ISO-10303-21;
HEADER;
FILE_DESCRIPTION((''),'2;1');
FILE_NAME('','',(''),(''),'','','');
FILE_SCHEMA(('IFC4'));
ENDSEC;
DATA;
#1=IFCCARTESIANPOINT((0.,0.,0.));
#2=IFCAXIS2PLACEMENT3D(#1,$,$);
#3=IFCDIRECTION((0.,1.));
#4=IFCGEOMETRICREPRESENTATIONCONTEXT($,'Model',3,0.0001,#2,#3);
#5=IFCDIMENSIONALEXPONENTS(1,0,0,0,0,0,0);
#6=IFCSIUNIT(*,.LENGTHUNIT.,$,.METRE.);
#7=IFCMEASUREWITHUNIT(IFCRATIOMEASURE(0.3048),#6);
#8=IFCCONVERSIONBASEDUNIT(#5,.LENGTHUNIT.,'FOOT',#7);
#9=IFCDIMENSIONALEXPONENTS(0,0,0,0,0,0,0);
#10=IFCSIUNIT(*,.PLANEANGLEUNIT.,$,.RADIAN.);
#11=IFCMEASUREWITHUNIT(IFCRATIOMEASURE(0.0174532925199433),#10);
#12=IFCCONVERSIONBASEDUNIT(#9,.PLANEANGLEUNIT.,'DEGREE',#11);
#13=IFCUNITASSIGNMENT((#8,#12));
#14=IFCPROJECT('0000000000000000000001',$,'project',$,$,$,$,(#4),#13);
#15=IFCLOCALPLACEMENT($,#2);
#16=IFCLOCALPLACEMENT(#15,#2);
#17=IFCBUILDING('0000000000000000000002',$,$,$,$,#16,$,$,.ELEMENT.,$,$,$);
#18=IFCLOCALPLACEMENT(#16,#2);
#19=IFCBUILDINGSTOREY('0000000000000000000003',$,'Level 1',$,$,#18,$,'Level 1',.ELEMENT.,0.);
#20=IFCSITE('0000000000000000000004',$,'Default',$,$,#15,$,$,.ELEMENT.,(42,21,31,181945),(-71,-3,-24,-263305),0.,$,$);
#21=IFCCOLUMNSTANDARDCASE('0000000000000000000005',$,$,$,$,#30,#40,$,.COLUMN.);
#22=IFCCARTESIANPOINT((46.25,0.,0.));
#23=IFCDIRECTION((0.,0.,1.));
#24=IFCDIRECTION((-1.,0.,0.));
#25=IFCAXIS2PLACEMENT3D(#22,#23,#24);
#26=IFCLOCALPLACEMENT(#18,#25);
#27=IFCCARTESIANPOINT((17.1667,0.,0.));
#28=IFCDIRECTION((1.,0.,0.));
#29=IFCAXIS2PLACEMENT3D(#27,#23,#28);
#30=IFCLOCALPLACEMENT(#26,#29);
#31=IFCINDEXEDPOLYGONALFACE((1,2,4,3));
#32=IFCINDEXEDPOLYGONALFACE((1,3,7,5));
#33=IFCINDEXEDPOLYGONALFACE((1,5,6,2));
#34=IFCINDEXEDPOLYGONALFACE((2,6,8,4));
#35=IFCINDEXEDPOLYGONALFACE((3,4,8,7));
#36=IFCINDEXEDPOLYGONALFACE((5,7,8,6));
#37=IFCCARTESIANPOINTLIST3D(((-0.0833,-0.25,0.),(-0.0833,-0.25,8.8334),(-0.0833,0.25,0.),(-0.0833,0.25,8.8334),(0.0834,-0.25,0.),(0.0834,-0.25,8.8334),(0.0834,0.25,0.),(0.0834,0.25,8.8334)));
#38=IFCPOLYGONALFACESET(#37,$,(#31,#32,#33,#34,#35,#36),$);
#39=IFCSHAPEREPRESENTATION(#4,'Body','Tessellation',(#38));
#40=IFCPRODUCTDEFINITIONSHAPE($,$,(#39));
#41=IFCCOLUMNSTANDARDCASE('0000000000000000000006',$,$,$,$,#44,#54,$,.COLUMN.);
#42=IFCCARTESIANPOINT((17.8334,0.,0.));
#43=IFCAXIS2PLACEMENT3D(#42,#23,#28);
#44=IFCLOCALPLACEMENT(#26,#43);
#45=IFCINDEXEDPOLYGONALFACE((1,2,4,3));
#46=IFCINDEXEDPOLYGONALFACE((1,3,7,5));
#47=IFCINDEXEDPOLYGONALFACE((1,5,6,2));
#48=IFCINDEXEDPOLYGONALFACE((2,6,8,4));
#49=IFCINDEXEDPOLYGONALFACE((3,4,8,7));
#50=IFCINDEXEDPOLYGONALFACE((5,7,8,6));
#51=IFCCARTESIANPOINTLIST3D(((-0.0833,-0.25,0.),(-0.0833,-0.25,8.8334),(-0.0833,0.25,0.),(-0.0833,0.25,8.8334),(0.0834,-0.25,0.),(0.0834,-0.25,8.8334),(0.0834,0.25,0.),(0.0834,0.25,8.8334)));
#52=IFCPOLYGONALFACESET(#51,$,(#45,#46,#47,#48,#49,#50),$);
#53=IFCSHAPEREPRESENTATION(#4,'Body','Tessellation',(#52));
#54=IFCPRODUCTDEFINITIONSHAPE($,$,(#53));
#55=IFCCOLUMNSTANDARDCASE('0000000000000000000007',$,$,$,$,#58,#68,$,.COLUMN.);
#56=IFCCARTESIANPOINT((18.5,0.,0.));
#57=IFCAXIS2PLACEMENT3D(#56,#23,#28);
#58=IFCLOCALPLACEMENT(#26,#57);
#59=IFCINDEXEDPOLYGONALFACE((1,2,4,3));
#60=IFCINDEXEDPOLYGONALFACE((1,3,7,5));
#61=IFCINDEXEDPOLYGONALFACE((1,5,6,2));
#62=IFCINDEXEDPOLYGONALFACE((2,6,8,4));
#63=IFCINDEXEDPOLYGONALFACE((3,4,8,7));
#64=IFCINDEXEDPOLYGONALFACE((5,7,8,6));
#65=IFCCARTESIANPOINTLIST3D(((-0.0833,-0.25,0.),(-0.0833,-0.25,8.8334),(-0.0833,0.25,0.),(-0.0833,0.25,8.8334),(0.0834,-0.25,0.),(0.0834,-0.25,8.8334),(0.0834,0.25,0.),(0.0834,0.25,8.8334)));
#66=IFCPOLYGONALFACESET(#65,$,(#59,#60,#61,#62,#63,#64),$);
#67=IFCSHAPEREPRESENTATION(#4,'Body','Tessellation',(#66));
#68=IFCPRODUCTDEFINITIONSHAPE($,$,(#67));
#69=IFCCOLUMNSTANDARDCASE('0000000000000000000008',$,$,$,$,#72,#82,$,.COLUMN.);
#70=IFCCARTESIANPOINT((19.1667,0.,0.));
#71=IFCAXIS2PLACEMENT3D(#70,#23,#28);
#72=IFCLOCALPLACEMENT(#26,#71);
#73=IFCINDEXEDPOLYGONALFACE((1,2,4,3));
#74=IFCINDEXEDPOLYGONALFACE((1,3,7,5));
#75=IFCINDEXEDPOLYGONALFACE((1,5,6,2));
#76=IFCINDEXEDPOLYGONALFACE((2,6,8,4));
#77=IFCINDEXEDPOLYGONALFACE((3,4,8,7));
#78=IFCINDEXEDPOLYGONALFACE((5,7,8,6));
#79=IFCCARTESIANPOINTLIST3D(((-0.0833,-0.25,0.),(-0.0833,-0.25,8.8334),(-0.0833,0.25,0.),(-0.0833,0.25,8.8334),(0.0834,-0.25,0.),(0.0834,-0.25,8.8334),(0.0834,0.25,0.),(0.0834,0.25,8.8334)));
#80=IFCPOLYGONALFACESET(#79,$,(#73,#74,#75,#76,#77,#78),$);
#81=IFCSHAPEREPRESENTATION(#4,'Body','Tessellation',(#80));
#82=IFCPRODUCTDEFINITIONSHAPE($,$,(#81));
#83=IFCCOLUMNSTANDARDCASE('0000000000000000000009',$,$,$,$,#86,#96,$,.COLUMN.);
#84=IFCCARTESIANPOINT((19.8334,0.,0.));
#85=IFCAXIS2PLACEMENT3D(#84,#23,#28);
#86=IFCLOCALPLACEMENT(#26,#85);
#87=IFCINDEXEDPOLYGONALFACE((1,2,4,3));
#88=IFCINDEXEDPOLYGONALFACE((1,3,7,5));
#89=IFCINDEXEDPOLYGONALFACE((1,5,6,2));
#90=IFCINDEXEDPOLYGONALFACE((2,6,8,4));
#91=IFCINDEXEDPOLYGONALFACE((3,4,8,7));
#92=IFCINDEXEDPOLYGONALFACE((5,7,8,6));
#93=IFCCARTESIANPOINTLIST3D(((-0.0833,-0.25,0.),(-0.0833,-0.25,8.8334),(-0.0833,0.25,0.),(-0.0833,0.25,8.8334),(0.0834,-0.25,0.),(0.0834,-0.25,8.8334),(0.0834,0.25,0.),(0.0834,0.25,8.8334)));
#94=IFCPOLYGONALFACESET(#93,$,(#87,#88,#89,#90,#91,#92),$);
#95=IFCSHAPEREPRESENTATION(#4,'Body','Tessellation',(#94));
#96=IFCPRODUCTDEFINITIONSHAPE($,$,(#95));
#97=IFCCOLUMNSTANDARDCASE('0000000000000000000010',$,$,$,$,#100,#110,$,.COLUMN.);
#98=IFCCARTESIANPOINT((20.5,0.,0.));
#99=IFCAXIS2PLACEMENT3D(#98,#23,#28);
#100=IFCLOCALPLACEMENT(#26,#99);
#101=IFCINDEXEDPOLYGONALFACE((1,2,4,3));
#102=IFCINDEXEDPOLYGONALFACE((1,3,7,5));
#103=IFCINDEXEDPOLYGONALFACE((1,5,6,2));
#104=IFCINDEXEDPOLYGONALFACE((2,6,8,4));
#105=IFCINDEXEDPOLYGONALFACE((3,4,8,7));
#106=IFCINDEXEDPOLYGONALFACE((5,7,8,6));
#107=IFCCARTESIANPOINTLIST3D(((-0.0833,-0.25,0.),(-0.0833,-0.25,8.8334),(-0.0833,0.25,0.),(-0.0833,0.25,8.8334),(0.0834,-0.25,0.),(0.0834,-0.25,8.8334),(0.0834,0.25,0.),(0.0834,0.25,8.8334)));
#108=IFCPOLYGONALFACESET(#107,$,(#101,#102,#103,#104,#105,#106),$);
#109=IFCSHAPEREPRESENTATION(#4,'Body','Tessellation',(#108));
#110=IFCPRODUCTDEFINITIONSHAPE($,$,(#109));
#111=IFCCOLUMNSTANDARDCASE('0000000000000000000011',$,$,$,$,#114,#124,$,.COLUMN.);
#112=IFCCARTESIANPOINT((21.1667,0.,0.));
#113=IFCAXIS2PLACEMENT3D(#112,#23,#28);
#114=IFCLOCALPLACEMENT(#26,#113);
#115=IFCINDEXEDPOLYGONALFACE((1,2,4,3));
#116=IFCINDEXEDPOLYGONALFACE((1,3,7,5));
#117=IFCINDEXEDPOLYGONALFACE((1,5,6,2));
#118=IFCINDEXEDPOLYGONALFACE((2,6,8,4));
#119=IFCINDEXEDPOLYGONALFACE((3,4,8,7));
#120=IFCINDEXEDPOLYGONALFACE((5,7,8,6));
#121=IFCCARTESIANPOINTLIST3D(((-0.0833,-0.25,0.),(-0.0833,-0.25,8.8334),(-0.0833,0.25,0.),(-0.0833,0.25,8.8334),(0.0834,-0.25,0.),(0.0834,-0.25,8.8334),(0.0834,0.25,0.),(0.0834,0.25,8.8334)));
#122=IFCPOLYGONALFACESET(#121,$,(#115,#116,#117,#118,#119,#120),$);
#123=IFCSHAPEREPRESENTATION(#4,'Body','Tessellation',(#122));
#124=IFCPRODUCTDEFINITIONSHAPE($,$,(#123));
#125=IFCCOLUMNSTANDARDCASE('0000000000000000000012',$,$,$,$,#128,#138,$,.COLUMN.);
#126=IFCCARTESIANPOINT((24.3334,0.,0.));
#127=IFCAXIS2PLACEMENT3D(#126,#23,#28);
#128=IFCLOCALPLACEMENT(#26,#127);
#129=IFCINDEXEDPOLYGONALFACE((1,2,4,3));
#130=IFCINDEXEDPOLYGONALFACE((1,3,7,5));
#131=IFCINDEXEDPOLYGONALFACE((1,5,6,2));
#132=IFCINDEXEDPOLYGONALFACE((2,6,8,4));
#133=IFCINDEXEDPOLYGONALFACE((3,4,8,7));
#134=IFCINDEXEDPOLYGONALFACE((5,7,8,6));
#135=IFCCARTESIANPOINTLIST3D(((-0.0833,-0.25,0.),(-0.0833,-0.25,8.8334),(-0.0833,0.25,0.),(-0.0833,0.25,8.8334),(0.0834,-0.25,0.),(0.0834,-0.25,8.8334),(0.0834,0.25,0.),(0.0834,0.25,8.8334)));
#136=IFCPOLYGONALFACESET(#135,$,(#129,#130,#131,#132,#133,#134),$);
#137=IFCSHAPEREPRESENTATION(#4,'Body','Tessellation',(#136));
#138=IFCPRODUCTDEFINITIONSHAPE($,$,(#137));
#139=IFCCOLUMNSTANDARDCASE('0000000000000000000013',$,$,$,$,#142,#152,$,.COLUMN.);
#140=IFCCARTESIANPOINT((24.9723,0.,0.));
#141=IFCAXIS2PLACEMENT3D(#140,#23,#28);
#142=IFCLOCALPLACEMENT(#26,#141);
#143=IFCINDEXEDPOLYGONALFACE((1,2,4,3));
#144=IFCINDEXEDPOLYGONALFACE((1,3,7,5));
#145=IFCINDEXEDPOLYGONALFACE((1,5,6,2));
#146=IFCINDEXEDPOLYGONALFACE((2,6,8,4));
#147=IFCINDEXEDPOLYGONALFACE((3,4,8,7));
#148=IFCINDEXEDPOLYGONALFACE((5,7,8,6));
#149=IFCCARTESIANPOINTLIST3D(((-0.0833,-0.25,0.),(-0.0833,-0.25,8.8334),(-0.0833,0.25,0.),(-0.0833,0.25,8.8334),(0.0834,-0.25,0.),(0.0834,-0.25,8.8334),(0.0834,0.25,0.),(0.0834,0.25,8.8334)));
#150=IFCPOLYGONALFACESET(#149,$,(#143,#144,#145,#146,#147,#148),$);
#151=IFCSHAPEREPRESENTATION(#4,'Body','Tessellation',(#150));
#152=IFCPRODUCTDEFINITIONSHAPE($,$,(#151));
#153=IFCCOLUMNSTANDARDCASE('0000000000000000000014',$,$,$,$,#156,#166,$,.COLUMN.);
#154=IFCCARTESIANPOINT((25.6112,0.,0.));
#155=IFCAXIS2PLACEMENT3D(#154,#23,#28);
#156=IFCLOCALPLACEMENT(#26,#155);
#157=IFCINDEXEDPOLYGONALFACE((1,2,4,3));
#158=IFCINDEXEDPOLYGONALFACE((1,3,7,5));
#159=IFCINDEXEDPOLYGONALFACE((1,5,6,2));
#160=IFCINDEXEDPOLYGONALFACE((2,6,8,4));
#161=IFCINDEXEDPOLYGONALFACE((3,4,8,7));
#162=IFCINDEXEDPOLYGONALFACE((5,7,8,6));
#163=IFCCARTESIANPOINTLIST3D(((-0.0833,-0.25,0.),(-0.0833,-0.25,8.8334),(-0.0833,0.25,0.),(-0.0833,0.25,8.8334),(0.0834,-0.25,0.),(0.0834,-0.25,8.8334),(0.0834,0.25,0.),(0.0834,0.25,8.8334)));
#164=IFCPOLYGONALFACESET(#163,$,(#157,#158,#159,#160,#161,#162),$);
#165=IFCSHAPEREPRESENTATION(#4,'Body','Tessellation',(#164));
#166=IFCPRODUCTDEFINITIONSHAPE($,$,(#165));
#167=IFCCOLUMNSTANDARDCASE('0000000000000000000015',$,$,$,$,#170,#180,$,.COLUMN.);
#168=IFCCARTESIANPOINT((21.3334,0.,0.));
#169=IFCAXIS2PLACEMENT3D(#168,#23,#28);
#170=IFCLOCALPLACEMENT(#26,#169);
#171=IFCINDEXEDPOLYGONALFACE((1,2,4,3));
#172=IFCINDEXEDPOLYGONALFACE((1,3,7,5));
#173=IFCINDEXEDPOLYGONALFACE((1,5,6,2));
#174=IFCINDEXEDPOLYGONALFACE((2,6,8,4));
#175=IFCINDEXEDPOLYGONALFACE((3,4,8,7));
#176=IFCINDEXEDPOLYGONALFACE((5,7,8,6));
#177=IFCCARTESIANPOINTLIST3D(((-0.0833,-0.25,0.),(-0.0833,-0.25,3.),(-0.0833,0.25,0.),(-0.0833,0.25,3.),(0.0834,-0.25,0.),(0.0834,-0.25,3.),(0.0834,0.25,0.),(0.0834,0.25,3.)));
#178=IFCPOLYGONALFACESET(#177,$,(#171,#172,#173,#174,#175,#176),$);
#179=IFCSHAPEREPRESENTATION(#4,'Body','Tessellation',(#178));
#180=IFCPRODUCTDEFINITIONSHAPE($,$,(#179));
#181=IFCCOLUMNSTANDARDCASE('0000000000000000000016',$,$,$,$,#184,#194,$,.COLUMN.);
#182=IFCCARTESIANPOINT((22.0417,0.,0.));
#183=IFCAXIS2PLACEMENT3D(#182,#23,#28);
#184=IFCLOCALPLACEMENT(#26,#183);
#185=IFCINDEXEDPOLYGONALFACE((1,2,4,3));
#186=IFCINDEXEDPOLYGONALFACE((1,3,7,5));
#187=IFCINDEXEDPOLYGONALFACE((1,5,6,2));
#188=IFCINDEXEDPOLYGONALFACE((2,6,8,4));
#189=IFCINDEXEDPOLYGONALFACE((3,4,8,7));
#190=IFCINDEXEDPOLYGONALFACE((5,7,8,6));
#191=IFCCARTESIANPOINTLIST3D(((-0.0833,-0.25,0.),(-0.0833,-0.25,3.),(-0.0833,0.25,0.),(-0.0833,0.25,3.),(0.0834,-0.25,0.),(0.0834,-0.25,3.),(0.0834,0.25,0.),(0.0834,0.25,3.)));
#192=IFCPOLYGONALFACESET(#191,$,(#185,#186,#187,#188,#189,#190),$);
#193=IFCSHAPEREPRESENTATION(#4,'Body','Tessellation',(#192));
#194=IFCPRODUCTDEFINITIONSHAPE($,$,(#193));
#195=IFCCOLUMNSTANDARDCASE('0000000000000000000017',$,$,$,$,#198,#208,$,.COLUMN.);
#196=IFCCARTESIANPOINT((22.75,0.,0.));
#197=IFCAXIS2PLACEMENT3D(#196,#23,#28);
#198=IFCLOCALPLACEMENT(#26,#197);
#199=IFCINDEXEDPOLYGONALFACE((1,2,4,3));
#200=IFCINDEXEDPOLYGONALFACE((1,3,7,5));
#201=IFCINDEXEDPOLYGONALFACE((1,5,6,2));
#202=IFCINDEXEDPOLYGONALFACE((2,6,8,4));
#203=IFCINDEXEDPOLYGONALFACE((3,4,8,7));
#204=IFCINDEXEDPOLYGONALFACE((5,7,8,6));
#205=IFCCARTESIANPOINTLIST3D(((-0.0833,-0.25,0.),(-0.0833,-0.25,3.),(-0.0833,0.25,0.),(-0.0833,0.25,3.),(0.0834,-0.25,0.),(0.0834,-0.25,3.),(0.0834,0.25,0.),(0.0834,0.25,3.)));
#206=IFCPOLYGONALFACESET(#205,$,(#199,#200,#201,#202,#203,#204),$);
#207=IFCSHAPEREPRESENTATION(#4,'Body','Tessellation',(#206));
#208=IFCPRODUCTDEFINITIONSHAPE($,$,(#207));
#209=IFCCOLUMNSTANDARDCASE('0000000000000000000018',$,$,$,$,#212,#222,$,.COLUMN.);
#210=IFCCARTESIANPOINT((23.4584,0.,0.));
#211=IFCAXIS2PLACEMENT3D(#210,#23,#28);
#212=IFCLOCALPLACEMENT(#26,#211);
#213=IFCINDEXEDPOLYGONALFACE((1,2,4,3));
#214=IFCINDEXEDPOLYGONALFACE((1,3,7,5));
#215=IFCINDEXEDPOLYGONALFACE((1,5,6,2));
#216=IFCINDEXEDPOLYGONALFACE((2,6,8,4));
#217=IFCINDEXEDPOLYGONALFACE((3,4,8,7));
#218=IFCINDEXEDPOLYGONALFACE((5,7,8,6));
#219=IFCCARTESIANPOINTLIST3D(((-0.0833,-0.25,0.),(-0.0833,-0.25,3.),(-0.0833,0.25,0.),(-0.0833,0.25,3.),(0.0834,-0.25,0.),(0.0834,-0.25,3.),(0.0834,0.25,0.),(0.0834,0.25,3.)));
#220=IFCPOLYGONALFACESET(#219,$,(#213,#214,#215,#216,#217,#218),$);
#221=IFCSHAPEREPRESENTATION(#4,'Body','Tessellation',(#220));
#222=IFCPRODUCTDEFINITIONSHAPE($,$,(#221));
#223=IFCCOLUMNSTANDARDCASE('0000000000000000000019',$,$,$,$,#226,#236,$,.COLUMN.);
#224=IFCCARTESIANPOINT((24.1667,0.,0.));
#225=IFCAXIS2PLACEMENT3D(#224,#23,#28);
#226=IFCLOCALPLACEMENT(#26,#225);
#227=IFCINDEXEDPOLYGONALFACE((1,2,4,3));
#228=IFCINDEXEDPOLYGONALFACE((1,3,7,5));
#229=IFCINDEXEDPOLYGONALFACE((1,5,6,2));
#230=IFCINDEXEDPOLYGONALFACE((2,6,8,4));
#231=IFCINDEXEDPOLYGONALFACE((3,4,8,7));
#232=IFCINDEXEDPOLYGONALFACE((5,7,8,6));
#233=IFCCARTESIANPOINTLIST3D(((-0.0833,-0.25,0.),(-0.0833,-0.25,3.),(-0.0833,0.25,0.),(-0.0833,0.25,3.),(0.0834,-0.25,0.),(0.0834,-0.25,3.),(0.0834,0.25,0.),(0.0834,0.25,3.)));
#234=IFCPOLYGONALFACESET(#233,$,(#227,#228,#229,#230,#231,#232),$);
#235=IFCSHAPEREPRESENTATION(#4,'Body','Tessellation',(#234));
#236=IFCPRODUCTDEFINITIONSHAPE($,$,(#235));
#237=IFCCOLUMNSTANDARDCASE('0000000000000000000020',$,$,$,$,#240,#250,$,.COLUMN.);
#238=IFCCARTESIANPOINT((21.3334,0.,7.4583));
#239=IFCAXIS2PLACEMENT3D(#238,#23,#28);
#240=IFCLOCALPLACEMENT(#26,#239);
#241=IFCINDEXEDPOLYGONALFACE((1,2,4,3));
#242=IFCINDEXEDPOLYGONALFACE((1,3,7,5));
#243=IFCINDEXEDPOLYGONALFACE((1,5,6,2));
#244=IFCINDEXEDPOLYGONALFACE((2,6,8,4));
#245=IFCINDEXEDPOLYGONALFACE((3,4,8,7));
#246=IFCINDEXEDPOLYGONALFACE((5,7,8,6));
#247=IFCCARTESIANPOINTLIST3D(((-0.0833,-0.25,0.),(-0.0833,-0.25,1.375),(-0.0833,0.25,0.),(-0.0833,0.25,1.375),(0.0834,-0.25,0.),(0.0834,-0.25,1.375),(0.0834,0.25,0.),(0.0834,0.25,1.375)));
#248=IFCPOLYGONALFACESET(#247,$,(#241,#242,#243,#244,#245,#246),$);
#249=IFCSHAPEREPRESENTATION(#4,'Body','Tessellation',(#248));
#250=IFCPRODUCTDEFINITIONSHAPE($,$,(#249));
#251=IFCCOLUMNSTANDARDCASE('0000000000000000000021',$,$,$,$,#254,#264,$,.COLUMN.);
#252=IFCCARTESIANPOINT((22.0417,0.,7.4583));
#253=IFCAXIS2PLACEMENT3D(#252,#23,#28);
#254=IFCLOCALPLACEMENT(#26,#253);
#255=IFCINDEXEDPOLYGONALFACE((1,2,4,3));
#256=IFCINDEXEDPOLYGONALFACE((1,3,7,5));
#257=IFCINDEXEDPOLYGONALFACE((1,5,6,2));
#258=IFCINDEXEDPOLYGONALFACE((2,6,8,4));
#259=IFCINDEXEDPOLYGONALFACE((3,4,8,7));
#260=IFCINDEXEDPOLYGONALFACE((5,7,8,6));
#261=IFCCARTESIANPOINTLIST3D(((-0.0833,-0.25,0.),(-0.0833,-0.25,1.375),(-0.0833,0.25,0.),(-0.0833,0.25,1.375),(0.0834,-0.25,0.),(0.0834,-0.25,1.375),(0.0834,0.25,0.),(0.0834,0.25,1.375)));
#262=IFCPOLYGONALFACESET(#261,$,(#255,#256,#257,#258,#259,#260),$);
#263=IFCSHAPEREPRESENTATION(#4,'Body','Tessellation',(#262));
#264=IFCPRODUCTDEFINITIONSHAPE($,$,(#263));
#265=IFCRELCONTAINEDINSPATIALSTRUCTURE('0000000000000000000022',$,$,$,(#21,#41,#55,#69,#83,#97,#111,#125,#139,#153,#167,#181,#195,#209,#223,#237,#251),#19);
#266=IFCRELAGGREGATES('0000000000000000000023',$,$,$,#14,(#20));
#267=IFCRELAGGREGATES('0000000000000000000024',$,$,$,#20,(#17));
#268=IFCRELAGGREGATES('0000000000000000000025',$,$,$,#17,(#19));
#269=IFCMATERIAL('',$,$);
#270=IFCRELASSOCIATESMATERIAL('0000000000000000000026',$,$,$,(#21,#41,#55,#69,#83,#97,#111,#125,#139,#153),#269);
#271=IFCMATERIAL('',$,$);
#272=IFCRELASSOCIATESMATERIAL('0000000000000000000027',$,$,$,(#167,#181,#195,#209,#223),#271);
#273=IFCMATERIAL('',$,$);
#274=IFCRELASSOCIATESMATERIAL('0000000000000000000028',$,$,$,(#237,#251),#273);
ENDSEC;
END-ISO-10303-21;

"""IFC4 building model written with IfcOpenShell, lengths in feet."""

from ifc_helpers import new_model, entity, si_unit, converted_unit, direction, frame, origin, place, context, project, spatial, rectangle, extrude, material, element, save


model = new_model("IFC4")

# Units and contexts
model_context = context("Model", 3, precision=0.0001, world=origin(), true_north=direction((0.0, 1.0)))
ifc_project = project(units=[converted_unit("LENGTHUNIT", "FOOT", entity("IfcRatioMeasure", 0.3048), si_unit("LENGTHUNIT", "METRE"), dimensions=[1, 0, 0, 0, 0, 0, 0]), converted_unit("PLANEANGLEUNIT", "DEGREE", entity("IfcRatioMeasure", 0.0174532925199433), si_unit("PLANEANGLEUNIT", "RADIAN"), dimensions=[0, 0, 0, 0, 0, 0, 0])], contexts=[model_context])

# Site, building, storey
site_placement = place(None, origin())
site = spatial("IfcSite", under=ifc_project, at=site_placement, Name="Default", CompositionType="ELEMENT", RefLatitude=(42, 21, 31, 181945), RefLongitude=(-71, -3, -24, -263305), RefElevation=0.0)
building_placement = place(site_placement, origin())
building = spatial("IfcBuilding", under=site, at=building_placement, CompositionType="ELEMENT")
storey_placement = place(building_placement, origin())
storey = spatial("IfcBuildingStorey", under=building, at=storey_placement, Name="Level 1", LongName="Level 1", CompositionType="ELEMENT", Elevation=0.0)

# Columns
ifc_material_1 = material(Name="")
placement_1 = place(storey_placement, frame((46.25, 0.0, 0.0), z_axis=(0.0, 0.0, 1.0), x_axis=(-1.0, 0.0, 0.0)))
for number, where, z_axis, x_axis in (
    (1, (17.1667, 0.0, 0.0), (0.0, 0.0, 1.0), (1.0, 0.0, 0.0)),
    (2, (17.8334, 0.0, 0.0), (0.0, 0.0, 1.0), (1.0, 0.0, 0.0)),
    (3, (18.5, 0.0, 0.0), (0.0, 0.0, 1.0), (1.0, 0.0, 0.0)),
    (4, (19.1667, 0.0, 0.0), (0.0, 0.0, 1.0), (1.0, 0.0, 0.0)),
    (5, (19.8334, 0.0, 0.0), (0.0, 0.0, 1.0), (1.0, 0.0, 0.0)),
    (6, (20.5, 0.0, 0.0), (0.0, 0.0, 1.0), (1.0, 0.0, 0.0)),
    (7, (21.1667, 0.0, 0.0), (0.0, 0.0, 1.0), (1.0, 0.0, 0.0)),
    (8, (24.3334, 0.0, 0.0), (0.0, 0.0, 1.0), (1.0, 0.0, 0.0)),
    (9, (24.9723, 0.0, 0.0), (0.0, 0.0, 1.0), (1.0, 0.0, 0.0)),
    (10, (25.6112, 0.0, 0.0), (0.0, 0.0, 1.0), (1.0, 0.0, 0.0)),
):
    element("IfcColumnStandardCase", number, at=place(placement_1, frame(where, z_axis=z_axis, x_axis=x_axis)), inside=storey, material=ifc_material_1, PredefinedType="COLUMN", context=model_context, shape_type="SweptSolid", body=[
        extrude(rectangle(XDim=0.1667, YDim=0.5), origin(), (0.0, 0.0, 1.0), 8.8334),
    ])
ifc_material_2 = material(Name="")
for number, where, z_axis, x_axis in (
    (11, (21.3334, 0.0, 0.0), (0.0, 0.0, 1.0), (1.0, 0.0, 0.0)),
    (12, (22.0417, 0.0, 0.0), (0.0, 0.0, 1.0), (1.0, 0.0, 0.0)),
    (13, (22.75, 0.0, 0.0), (0.0, 0.0, 1.0), (1.0, 0.0, 0.0)),
    (14, (23.4584, 0.0, 0.0), (0.0, 0.0, 1.0), (1.0, 0.0, 0.0)),
    (15, (24.1667, 0.0, 0.0), (0.0, 0.0, 1.0), (1.0, 0.0, 0.0)),
):
    element("IfcColumnStandardCase", number, at=place(placement_1, frame(where, z_axis=z_axis, x_axis=x_axis)), inside=storey, material=ifc_material_2, PredefinedType="COLUMN", context=model_context, shape_type="SweptSolid", body=[
        extrude(rectangle(XDim=0.1667, YDim=0.5), origin(), (0.0, 0.0, 1.0), 3.0),
    ])
ifc_material_3 = material(Name="")
for number, where, z_axis, x_axis in (
    (16, (21.3334, 0.0, 7.4583), (0.0, 0.0, 1.0), (1.0, 0.0, 0.0)),
    (17, (22.0417, 0.0, 7.4583), (0.0, 0.0, 1.0), (1.0, 0.0, 0.0)),
):
    element("IfcColumnStandardCase", number, at=place(placement_1, frame(where, z_axis=z_axis, x_axis=x_axis)), inside=storey, material=ifc_material_3, PredefinedType="COLUMN", context=model_context, shape_type="SweptSolid", body=[
        extrude(rectangle(XDim=0.1667, YDim=0.5), origin(), (0.0, 0.0, 1.0), 1.375),
    ])

save(model, "model.ifc")
